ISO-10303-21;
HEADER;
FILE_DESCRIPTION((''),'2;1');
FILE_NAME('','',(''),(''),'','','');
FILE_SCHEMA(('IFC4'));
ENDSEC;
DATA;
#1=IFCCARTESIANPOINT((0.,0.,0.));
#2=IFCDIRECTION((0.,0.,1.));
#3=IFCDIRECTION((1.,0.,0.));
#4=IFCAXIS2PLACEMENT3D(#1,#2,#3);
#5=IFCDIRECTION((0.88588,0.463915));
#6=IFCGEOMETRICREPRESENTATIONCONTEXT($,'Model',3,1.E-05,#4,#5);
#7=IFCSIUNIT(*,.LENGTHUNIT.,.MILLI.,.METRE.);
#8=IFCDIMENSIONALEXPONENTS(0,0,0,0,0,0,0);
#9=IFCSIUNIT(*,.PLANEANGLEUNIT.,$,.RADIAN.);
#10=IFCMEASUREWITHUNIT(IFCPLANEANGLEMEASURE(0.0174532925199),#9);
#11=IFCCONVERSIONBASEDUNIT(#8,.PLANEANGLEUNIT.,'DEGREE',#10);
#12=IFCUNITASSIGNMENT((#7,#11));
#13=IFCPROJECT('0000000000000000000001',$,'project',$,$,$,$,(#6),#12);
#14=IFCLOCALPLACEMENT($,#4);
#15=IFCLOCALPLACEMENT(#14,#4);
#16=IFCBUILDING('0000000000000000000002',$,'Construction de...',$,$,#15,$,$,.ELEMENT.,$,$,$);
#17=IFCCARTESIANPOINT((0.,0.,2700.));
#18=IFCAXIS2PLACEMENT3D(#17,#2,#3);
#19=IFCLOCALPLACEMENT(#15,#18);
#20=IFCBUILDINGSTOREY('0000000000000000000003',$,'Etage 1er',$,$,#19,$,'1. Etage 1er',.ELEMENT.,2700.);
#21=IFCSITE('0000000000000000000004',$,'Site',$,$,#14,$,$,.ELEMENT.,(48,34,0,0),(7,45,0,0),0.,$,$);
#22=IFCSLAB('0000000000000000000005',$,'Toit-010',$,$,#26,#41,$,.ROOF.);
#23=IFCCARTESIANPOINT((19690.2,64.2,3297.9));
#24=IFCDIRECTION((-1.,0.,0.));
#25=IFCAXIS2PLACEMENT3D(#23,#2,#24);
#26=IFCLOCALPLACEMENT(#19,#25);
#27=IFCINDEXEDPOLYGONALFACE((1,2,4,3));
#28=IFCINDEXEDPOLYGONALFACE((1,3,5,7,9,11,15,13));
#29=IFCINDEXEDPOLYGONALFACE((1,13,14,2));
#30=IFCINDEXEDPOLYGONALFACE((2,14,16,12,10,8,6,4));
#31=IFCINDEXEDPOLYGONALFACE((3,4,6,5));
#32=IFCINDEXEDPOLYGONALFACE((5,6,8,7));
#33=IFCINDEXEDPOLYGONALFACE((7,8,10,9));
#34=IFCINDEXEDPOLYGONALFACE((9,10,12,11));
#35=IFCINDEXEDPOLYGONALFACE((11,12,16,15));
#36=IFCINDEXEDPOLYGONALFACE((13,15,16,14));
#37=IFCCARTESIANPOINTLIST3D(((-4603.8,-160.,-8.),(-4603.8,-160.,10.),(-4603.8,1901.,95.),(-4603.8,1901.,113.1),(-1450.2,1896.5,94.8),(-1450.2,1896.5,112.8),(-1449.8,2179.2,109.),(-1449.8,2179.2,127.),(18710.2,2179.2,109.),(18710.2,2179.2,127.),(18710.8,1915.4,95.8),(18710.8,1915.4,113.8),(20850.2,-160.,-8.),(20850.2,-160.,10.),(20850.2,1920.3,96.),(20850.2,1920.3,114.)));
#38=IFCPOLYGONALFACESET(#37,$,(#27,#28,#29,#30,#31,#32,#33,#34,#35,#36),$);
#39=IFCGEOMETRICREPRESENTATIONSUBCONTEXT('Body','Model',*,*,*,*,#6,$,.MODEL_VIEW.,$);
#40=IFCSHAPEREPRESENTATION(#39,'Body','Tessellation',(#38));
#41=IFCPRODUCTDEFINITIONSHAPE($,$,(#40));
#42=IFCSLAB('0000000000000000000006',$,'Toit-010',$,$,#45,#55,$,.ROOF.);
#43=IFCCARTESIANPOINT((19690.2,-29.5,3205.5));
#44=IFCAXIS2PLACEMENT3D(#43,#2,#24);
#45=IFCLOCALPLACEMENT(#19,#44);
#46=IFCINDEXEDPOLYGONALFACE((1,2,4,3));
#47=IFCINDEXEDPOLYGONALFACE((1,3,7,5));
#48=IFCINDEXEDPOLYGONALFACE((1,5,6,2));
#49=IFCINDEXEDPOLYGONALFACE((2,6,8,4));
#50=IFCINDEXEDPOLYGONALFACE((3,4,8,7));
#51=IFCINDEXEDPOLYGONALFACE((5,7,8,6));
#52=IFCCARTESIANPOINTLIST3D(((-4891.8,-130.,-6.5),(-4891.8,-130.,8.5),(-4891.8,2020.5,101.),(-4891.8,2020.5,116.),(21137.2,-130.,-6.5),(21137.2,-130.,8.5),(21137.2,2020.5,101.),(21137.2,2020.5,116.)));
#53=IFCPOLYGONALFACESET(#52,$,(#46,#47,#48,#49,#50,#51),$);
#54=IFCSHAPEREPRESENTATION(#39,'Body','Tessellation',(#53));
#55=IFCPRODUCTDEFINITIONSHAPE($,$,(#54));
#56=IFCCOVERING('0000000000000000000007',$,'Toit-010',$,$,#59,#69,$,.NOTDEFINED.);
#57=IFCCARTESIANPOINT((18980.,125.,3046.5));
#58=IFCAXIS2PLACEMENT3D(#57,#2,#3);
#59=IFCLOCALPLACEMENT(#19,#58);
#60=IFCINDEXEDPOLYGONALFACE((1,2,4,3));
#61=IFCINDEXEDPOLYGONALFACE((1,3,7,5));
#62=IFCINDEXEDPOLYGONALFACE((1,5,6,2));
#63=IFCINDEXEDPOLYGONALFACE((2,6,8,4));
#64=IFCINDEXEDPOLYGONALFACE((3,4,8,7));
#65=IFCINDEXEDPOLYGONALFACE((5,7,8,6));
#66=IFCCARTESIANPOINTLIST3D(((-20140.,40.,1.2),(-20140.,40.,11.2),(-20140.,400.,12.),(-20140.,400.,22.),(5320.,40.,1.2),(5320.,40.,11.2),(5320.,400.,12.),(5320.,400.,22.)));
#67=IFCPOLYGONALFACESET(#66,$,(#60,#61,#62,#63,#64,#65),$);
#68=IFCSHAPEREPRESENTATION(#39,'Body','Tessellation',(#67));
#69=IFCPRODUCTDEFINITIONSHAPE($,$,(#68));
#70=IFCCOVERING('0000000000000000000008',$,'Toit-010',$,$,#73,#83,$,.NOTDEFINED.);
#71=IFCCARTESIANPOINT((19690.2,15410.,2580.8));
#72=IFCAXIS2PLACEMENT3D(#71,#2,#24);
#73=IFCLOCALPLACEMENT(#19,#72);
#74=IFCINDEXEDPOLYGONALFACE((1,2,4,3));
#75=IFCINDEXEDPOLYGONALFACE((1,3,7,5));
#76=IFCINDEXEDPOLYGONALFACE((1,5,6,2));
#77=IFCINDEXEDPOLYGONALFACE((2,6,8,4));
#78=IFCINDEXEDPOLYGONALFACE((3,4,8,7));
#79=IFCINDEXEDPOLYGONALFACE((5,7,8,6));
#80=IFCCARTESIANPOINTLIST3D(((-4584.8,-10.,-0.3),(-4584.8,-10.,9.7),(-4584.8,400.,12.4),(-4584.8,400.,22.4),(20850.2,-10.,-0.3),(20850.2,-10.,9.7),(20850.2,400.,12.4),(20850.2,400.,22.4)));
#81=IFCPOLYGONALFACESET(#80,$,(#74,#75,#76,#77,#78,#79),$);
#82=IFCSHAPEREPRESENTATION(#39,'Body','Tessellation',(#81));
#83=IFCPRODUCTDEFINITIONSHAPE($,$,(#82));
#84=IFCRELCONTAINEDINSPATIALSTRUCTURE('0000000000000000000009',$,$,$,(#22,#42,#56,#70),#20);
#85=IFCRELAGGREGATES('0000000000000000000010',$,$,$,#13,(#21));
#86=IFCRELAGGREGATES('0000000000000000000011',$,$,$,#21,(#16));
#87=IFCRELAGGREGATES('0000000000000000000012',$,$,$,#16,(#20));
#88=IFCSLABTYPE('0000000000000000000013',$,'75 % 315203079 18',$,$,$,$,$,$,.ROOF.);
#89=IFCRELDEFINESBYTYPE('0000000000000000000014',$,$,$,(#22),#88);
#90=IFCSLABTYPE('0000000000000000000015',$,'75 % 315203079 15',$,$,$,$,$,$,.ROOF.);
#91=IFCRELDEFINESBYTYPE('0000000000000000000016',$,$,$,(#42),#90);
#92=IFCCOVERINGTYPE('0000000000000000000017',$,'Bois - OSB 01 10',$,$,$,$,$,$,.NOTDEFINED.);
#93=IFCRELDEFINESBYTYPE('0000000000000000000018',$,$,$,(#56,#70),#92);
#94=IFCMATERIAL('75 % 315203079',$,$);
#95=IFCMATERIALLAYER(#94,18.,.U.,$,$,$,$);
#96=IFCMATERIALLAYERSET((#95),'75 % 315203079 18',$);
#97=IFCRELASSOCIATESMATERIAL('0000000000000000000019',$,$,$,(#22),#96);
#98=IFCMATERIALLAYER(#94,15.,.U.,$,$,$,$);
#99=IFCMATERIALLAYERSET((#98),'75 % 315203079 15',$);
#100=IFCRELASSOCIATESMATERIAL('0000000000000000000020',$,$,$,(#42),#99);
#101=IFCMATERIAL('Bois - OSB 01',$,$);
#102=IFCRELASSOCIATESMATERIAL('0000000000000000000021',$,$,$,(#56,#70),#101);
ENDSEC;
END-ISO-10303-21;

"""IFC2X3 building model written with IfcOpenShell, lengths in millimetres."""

from ifc_helpers import new_model, entity, si_unit, converted_unit, direction, frame, origin_with_axes, place, context, subcontext, project, spatial, polyline, outline, extrude, material, layer, layer_set, layer_usage, type_object, element, save


model = new_model("IFC2X3")

# Units and contexts
model_context = context("Model", 3, precision=1e-05, world=origin_with_axes(), true_north=direction((0.88588, 0.463915)))
body_context = subcontext(model_context, "Body", "Model", "MODEL_VIEW")
ifc_project = project(units=[si_unit("LENGTHUNIT", "METRE", prefix="MILLI"), converted_unit("PLANEANGLEUNIT", "DEGREE", entity("IfcPlaneAngleMeasure", 0.0174532925199), si_unit("PLANEANGLEUNIT", "RADIAN"), dimensions=[0, 0, 0, 0, 0, 0, 0])], contexts=[model_context])

# Site, building, storey
site_placement = place(None, origin_with_axes())
site = spatial("IfcSite", under=ifc_project, at=site_placement, Name="Site", CompositionType="ELEMENT", RefLatitude=(48, 34, 0, 0), RefLongitude=(7, 45, 0, 0), RefElevation=0.0)
building_placement = place(site_placement, origin_with_axes())
building = spatial("IfcBuilding", under=site, at=building_placement, Name="Construction de...", CompositionType="ELEMENT")
storey_placement = place(building_placement, frame((0.0, 0.0, 2700.0), z_axis=(0.0, 0.0, 1.0), x_axis=(1.0, 0.0, 0.0)))
storey = spatial("IfcBuildingStorey", under=building, at=storey_placement, Name="Etage 1er", LongName="1. Etage 1er", CompositionType="ELEMENT", Elevation=2700.0)

# Slabs
ifc_material_1 = material(Name="75 % 315203079")
ifc_layer_1 = layer(ifc_material_1, 18.0, ventilated="UNKNOWN")
ifc_layer_set_1 = layer_set([ifc_layer_1], Name="75 % 315203079 18")
ifc_layer_usage_1 = layer_usage(ifc_layer_set_1, "AXIS3", "NEGATIVE", 18.0)
slab_type_1 = type_object("IfcSlabType", Name="75 % 315203079 18", PredefinedType="ROOF")
slab_1_placement = place(storey_placement, frame((19690.2, 64.2, 3297.9), z_axis=(0.0, 0.0, 1.0), x_axis=(-1.0, 0.0, 0.0)))
element("IfcSlab", 1, at=slab_1_placement, inside=storey, type_object=slab_type_1, material=ifc_layer_usage_1, Name="Toit-010", PredefinedType="ROOF", context=body_context, shape_type="SweptSolid", body=[
    extrude(outline(polyline([(-4603.8, -160.2), (20850.2, -160.2), (20850.2, 1922.7), (18710.8, 1917.8), (18710.2, 2181.9), (-1449.8, 2181.9), (-1450.2, 1898.9), (-4603.8, 1903.4), (-4603.8, -160.2)])), frame((0.0, 0.0, 0.0), z_axis=(0.0, -0.049938, 0.998752), x_axis=(1.0, 0.0, 0.0)), (0.0, 0.049938, 0.998752), 18.0),
])
ifc_layer_2 = layer(ifc_material_1, 15.0, ventilated="UNKNOWN")
ifc_layer_set_2 = layer_set([ifc_layer_2], Name="75 % 315203079 15")
ifc_layer_usage_2 = layer_usage(ifc_layer_set_2, "AXIS3", "NEGATIVE", 15.0)
slab_type_2 = type_object("IfcSlabType", Name="75 % 315203079 15", PredefinedType="ROOF")
slab_2_placement = place(storey_placement, frame((19690.2, -29.5, 3205.5), z_axis=(0.0, 0.0, 1.0), x_axis=(-1.0, 0.0, 0.0)))
element("IfcSlab", 2, at=slab_2_placement, inside=storey, type_object=slab_type_2, material=ifc_layer_usage_2, Name="Toit-010", PredefinedType="ROOF", context=body_context, shape_type="SweptSolid", body=[
    extrude(outline(polyline([(-4891.8, -130.2), (21137.2, -130.2), (21137.2, 2023.0), (-4891.8, 2023.0), (-4891.8, -130.2)])), frame((0.0, 0.0, 0.0), z_axis=(0.0, -0.049938, 0.998752), x_axis=(1.0, 0.0, 0.0)), (0.0, 0.049938, 0.998752), 15.0),
])

# Coverings
ifc_material_2 = material(Name="Bois - OSB 01")
covering_type = type_object("IfcCoveringType", Name="Bois - OSB 01 10", PredefinedType="NOTDEFINED")
covering_1_placement = place(storey_placement, frame((18980.0, 125.0, 3046.5), z_axis=(0.0, 0.0, 1.0), x_axis=(1.0, 0.0, 0.0)))
element("IfcCovering", 3, at=covering_1_placement, inside=storey, type_object=covering_type, material=ifc_material_2, Name="Toit-010", PredefinedType="NOTDEFINED", context=body_context, shape_type="SweptSolid", body=[
    extrude(outline(polyline([(5320.0, 400.2), (-20140.0, 400.2), (-20140.0, 40.0), (5320.0, 40.0), (5320.0, 400.2)])), frame((0.0, 0.0, 0.0), z_axis=(0.0, -0.029987, 0.99955), x_axis=(1.0, 0.0, 0.0)), (0.0, 0.029987, 0.99955), 10.0),
])
covering_2_placement = place(storey_placement, frame((19690.2, 15410.0, 2580.8), z_axis=(0.0, 0.0, 1.0), x_axis=(-1.0, 0.0, 0.0)))
element("IfcCovering", 4, at=covering_2_placement, inside=storey, type_object=covering_type, material=ifc_material_2, Name="Toit-010", PredefinedType="NOTDEFINED", context=body_context, shape_type="SweptSolid", body=[
    extrude(outline(polyline([(-4584.8, -10.0), (20850.2, -10.0), (20850.2, 400.2), (-4584.8, 400.2), (-4584.8, -10.0)])), frame((0.0, 0.0, 0.0), z_axis=(0.0, -0.030985, 0.99952), x_axis=(1.0, 0.0, 0.0)), (0.0, 0.030985, 0.99952), 10.0),
])

save(model, "model.ifc")
